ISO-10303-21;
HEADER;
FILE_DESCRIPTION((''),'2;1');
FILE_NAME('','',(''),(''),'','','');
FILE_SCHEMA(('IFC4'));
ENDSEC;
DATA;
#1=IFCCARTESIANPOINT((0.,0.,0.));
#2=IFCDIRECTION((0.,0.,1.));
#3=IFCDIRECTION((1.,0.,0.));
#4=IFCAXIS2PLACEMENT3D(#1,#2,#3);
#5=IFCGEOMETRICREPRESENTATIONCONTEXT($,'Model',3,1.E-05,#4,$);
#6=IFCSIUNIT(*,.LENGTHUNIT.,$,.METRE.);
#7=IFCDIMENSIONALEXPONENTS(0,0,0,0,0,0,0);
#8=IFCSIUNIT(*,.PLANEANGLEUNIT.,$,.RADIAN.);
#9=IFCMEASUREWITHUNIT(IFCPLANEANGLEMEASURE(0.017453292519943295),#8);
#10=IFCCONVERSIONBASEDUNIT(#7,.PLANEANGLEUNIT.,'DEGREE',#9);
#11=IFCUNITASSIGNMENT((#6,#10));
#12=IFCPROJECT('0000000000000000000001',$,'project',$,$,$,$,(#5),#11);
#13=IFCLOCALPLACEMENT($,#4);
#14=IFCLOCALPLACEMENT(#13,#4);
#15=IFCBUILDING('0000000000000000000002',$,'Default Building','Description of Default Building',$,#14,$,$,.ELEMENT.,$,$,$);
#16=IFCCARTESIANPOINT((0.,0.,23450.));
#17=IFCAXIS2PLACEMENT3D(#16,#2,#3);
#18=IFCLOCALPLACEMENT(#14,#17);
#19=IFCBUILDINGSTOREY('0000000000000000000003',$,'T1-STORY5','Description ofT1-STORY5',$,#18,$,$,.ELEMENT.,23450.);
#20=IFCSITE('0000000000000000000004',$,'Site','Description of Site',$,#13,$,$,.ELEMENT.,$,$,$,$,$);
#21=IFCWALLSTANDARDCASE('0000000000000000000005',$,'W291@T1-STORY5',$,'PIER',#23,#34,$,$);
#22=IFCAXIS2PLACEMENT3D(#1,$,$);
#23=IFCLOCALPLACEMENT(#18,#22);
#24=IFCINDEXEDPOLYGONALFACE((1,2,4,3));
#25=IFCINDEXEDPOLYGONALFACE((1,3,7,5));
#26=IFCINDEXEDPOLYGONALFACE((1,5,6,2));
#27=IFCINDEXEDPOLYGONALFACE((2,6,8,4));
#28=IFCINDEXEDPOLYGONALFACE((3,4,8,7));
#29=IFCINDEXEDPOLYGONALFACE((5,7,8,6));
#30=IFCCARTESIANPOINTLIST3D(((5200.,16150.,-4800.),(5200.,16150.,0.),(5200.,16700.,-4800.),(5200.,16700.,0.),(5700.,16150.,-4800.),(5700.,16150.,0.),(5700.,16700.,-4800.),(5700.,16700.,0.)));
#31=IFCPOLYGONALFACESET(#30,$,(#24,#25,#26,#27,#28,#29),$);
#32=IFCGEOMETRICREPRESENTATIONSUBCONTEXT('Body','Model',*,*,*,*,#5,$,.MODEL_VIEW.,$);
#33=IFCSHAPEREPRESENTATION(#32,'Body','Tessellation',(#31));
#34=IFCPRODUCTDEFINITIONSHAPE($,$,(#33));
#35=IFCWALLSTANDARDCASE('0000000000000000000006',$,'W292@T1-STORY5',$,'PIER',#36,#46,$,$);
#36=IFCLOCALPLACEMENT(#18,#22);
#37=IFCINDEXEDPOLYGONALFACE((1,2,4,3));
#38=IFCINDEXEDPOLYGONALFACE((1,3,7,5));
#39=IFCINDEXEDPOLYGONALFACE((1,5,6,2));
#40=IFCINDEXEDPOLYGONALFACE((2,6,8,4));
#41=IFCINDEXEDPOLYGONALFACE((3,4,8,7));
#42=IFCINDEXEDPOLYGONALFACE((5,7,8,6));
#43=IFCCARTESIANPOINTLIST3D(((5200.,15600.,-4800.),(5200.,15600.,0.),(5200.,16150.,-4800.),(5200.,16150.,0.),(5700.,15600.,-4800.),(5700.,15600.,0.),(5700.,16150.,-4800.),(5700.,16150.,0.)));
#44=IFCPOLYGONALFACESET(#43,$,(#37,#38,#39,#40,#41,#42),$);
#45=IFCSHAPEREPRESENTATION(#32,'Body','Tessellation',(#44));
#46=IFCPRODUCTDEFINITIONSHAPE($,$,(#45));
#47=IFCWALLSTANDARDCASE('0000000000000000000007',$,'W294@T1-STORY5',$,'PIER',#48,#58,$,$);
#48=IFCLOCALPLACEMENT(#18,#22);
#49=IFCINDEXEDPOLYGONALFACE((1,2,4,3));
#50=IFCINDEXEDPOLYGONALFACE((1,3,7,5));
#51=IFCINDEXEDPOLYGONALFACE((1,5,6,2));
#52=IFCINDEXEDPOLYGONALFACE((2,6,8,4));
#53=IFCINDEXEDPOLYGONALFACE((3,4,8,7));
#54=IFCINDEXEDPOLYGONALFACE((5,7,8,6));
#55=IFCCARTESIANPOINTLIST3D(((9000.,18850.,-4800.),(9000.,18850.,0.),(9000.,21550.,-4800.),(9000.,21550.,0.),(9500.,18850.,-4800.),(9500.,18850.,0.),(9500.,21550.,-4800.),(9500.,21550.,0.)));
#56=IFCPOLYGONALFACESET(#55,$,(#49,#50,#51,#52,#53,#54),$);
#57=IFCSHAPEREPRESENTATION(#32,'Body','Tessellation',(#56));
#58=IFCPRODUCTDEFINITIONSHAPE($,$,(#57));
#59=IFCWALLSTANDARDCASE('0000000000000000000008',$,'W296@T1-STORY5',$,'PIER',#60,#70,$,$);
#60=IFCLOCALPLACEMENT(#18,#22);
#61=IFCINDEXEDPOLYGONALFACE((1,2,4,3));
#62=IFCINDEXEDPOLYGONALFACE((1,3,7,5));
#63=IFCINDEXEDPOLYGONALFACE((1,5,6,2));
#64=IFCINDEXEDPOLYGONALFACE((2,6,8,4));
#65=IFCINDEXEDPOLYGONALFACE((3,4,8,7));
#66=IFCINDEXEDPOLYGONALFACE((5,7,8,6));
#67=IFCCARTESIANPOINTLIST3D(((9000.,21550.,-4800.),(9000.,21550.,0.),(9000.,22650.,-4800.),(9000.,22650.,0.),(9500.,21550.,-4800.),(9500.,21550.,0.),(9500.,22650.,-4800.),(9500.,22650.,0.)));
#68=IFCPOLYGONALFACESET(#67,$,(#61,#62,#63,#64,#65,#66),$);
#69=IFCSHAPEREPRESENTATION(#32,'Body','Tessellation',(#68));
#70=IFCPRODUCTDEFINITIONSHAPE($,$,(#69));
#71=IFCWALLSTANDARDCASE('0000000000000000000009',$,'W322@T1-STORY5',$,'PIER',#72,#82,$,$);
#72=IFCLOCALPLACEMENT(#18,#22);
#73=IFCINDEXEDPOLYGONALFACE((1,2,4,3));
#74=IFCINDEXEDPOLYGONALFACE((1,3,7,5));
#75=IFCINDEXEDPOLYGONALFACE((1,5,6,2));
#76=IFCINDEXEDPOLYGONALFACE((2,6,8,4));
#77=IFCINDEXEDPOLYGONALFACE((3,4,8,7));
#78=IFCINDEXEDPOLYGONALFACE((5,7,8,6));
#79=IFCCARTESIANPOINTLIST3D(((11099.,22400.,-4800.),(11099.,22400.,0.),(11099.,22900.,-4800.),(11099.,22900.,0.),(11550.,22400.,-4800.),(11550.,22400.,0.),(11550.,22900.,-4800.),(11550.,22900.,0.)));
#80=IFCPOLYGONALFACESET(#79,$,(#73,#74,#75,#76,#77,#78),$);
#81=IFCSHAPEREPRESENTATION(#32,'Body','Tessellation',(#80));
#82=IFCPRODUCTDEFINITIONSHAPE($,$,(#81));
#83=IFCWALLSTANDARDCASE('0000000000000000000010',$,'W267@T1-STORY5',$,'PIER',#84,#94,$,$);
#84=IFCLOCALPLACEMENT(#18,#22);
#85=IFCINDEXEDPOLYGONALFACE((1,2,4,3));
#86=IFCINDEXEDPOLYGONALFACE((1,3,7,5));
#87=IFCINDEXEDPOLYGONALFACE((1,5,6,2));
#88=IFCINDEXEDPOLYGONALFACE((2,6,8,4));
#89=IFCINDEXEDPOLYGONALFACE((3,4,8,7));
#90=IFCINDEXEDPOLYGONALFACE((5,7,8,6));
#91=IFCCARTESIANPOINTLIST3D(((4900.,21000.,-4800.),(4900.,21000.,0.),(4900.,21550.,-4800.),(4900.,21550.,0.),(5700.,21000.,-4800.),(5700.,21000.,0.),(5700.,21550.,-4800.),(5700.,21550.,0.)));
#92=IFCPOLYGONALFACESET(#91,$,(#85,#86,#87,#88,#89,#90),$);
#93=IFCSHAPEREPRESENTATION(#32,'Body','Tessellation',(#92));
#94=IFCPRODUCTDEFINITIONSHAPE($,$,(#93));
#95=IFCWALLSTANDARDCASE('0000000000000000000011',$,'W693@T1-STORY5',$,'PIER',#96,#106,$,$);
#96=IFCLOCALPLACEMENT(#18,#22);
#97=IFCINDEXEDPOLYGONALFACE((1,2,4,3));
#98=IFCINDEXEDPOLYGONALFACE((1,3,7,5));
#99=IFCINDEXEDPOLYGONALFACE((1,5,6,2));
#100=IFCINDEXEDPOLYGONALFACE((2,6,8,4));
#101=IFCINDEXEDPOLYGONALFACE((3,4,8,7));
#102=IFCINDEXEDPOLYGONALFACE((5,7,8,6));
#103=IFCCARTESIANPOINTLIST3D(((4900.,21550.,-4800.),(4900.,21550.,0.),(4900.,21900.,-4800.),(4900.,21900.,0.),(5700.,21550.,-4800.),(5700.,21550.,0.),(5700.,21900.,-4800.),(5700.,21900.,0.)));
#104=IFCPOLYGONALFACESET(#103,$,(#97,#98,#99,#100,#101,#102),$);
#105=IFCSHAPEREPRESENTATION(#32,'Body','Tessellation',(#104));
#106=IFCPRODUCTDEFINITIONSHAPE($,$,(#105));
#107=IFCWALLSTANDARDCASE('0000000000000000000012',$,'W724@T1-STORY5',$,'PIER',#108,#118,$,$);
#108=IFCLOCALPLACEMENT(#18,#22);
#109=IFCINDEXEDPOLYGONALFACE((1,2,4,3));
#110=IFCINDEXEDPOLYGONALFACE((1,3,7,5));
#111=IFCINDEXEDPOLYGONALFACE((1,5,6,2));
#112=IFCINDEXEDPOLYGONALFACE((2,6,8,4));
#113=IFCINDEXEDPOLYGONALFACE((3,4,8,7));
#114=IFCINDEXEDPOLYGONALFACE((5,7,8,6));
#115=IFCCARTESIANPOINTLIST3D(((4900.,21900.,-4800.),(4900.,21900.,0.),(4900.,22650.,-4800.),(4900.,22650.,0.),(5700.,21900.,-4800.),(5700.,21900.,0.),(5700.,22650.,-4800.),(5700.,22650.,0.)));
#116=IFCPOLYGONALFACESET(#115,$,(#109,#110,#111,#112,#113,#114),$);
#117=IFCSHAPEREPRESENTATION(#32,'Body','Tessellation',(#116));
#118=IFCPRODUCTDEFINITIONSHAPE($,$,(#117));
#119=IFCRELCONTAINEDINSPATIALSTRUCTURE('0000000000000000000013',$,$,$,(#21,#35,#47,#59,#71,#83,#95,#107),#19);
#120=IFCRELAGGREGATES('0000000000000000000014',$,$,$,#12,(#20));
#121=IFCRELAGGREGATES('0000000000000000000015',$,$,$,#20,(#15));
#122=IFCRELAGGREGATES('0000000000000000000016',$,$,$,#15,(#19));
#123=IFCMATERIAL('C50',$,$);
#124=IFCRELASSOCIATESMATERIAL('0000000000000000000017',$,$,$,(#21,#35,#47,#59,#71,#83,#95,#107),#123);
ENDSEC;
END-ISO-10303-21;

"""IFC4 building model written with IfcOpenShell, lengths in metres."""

from ifc_helpers import new_model, entity, si_unit, converted_unit, frame, origin_with_axes, place, context, subcontext, project, spatial, indexed_curve, outline, extrude, material, element, save


model = new_model("IFC4")

# Units and contexts
model_context = context("Model", 3, precision=1e-05, world=origin_with_axes())
body_context = subcontext(model_context, "Body", "Model", "MODEL_VIEW")
ifc_project = project(units=[si_unit("LENGTHUNIT", "METRE"), converted_unit("PLANEANGLEUNIT", "DEGREE", entity("IfcPlaneAngleMeasure", 0.017453292519943295), si_unit("PLANEANGLEUNIT", "RADIAN"), dimensions=[0, 0, 0, 0, 0, 0, 0])], contexts=[model_context])

# Site, building, storey
site_placement = place(None, origin_with_axes())
site = spatial("IfcSite", under=ifc_project, at=site_placement, Name="Site", Description="Description of Site", CompositionType="ELEMENT")
building_placement = place(site_placement, origin_with_axes())
building = spatial("IfcBuilding", under=site, at=building_placement, Name="Default Building", Description="Description of Default Building", CompositionType="ELEMENT")
storey_placement = place(building_placement, frame((0.0, 0.0, 23450.0), z_axis=(0.0, 0.0, 1.0), x_axis=(1.0, 0.0, 0.0)))
storey = spatial("IfcBuildingStorey", under=building, at=storey_placement, Name="T1-STORY5", Description="Description ofT1-STORY5", CompositionType="ELEMENT", Elevation=23450.0)

# Shared definitions
ifc_material_1 = material(Name="C50")

# Walls
for number, where, z_axis, x_axis, name in (
    (1, (5450.0, 16150.0, -4800.0), (0.0, 0.0, 1.0), (0.0, 1.0, 0.0), "W291@T1-STORY5"),
    (2, (5450.0, 15600.0, -4800.0), (0.0, 0.0, 1.0), (0.0, 1.0, 0.0), "W292@T1-STORY5"),
):
    element("IfcWallStandardCase", number, at=place(storey_placement, frame(where, z_axis=z_axis, x_axis=x_axis)), inside=storey, material=ifc_material_1, Name=name, ObjectType="PIER", context=body_context, shape_type="SweptSolid", body=[
        extrude(outline(indexed_curve([(0.0, -250.0), (0.0, 250.0), (550.0, 250.0), (550.0, -250.0), (0.0, -250.0)], self_intersect=False)), origin_with_axes(), (0.0, 0.0, 1.0), 4800.0),
    ])
wall_1_placement = place(storey_placement, frame((9250.0, 18850.0, -4800.0), z_axis=(0.0, 0.0, 1.0), x_axis=(0.0, 1.0, 0.0)))
element("IfcWallStandardCase", 3, at=wall_1_placement, inside=storey, material=ifc_material_1, Name="W294@T1-STORY5", ObjectType="PIER", context=body_context, shape_type="SweptSolid", body=[
    extrude(outline(indexed_curve([(0.0, -250.0), (0.0, 250.0), (2700.0, 250.0), (2700.0, -250.0), (0.0, -250.0)], self_intersect=False)), origin_with_axes(), (0.0, 0.0, 1.0), 4800.0),
])
wall_2_placement = place(storey_placement, frame((9250.0, 21550.0, -4800.0), z_axis=(0.0, 0.0, 1.0), x_axis=(0.0, 1.0, 0.0)))
element("IfcWallStandardCase", 4, at=wall_2_placement, inside=storey, material=ifc_material_1, Name="W296@T1-STORY5", ObjectType="PIER", context=body_context, shape_type="SweptSolid", body=[
    extrude(outline(indexed_curve([(0.0, -250.0), (0.0, 250.0), (1100.0, 250.0), (1100.0, -250.0), (0.0, -250.0)], self_intersect=False)), origin_with_axes(), (0.0, 0.0, 1.0), 4800.0),
])
wall_3_placement = place(storey_placement, frame((11099.0, 22650.0, -4800.0), z_axis=(0.0, 0.0, 1.0), x_axis=(1.0, 0.0, 0.0)))
element("IfcWallStandardCase", 5, at=wall_3_placement, inside=storey, material=ifc_material_1, Name="W322@T1-STORY5", ObjectType="PIER", context=body_context, shape_type="SweptSolid", body=[
    extrude(outline(indexed_curve([(0.0, -250.0), (0.0, 250.0), (451.0, 250.0), (451.0, -250.0), (0.0, -250.0)], self_intersect=False)), origin_with_axes(), (0.0, 0.0, 1.0), 4800.0),
])
wall_4_placement = place(storey_placement, frame((5300.0, 21000.0, -4800.0), z_axis=(0.0, 0.0, 1.0), x_axis=(0.0, 1.0, 0.0)))
element("IfcWallStandardCase", 6, at=wall_4_placement, inside=storey, material=ifc_material_1, Name="W267@T1-STORY5", ObjectType="PIER", context=body_context, shape_type="SweptSolid", body=[
    extrude(outline(indexed_curve([(0.0, -400.0), (0.0, 400.0), (550.0, 400.0), (550.0, -400.0), (0.0, -400.0)], self_intersect=False)), origin_with_axes(), (0.0, 0.0, 1.0), 4800.0),
])
wall_5_placement = place(storey_placement, frame((5300.0, 21550.0, -4800.0), z_axis=(0.0, 0.0, 1.0), x_axis=(0.0, 1.0, 0.0)))
element("IfcWallStandardCase", 7, at=wall_5_placement, inside=storey, material=ifc_material_1, Name="W693@T1-STORY5", ObjectType="PIER", context=body_context, shape_type="SweptSolid", body=[
    extrude(outline(indexed_curve([(0.0, -400.0), (0.0, 400.0), (350.0, 400.0), (350.0, -400.0), (0.0, -400.0)], self_intersect=False)), origin_with_axes(), (0.0, 0.0, 1.0), 4800.0),
])
wall_6_placement = place(storey_placement, frame((5300.0, 21900.0, -4800.0), z_axis=(0.0, 0.0, 1.0), x_axis=(0.0, 1.0, 0.0)))
element("IfcWallStandardCase", 8, at=wall_6_placement, inside=storey, material=ifc_material_1, Name="W724@T1-STORY5", ObjectType="PIER", context=body_context, shape_type="SweptSolid", body=[
    extrude(outline(indexed_curve([(0.0, -400.0), (0.0, 400.0), (750.0, 400.0), (750.0, -400.0), (0.0, -400.0)], self_intersect=False)), origin_with_axes(), (0.0, 0.0, 1.0), 4800.0),
])

save(model, "model.ifc")
